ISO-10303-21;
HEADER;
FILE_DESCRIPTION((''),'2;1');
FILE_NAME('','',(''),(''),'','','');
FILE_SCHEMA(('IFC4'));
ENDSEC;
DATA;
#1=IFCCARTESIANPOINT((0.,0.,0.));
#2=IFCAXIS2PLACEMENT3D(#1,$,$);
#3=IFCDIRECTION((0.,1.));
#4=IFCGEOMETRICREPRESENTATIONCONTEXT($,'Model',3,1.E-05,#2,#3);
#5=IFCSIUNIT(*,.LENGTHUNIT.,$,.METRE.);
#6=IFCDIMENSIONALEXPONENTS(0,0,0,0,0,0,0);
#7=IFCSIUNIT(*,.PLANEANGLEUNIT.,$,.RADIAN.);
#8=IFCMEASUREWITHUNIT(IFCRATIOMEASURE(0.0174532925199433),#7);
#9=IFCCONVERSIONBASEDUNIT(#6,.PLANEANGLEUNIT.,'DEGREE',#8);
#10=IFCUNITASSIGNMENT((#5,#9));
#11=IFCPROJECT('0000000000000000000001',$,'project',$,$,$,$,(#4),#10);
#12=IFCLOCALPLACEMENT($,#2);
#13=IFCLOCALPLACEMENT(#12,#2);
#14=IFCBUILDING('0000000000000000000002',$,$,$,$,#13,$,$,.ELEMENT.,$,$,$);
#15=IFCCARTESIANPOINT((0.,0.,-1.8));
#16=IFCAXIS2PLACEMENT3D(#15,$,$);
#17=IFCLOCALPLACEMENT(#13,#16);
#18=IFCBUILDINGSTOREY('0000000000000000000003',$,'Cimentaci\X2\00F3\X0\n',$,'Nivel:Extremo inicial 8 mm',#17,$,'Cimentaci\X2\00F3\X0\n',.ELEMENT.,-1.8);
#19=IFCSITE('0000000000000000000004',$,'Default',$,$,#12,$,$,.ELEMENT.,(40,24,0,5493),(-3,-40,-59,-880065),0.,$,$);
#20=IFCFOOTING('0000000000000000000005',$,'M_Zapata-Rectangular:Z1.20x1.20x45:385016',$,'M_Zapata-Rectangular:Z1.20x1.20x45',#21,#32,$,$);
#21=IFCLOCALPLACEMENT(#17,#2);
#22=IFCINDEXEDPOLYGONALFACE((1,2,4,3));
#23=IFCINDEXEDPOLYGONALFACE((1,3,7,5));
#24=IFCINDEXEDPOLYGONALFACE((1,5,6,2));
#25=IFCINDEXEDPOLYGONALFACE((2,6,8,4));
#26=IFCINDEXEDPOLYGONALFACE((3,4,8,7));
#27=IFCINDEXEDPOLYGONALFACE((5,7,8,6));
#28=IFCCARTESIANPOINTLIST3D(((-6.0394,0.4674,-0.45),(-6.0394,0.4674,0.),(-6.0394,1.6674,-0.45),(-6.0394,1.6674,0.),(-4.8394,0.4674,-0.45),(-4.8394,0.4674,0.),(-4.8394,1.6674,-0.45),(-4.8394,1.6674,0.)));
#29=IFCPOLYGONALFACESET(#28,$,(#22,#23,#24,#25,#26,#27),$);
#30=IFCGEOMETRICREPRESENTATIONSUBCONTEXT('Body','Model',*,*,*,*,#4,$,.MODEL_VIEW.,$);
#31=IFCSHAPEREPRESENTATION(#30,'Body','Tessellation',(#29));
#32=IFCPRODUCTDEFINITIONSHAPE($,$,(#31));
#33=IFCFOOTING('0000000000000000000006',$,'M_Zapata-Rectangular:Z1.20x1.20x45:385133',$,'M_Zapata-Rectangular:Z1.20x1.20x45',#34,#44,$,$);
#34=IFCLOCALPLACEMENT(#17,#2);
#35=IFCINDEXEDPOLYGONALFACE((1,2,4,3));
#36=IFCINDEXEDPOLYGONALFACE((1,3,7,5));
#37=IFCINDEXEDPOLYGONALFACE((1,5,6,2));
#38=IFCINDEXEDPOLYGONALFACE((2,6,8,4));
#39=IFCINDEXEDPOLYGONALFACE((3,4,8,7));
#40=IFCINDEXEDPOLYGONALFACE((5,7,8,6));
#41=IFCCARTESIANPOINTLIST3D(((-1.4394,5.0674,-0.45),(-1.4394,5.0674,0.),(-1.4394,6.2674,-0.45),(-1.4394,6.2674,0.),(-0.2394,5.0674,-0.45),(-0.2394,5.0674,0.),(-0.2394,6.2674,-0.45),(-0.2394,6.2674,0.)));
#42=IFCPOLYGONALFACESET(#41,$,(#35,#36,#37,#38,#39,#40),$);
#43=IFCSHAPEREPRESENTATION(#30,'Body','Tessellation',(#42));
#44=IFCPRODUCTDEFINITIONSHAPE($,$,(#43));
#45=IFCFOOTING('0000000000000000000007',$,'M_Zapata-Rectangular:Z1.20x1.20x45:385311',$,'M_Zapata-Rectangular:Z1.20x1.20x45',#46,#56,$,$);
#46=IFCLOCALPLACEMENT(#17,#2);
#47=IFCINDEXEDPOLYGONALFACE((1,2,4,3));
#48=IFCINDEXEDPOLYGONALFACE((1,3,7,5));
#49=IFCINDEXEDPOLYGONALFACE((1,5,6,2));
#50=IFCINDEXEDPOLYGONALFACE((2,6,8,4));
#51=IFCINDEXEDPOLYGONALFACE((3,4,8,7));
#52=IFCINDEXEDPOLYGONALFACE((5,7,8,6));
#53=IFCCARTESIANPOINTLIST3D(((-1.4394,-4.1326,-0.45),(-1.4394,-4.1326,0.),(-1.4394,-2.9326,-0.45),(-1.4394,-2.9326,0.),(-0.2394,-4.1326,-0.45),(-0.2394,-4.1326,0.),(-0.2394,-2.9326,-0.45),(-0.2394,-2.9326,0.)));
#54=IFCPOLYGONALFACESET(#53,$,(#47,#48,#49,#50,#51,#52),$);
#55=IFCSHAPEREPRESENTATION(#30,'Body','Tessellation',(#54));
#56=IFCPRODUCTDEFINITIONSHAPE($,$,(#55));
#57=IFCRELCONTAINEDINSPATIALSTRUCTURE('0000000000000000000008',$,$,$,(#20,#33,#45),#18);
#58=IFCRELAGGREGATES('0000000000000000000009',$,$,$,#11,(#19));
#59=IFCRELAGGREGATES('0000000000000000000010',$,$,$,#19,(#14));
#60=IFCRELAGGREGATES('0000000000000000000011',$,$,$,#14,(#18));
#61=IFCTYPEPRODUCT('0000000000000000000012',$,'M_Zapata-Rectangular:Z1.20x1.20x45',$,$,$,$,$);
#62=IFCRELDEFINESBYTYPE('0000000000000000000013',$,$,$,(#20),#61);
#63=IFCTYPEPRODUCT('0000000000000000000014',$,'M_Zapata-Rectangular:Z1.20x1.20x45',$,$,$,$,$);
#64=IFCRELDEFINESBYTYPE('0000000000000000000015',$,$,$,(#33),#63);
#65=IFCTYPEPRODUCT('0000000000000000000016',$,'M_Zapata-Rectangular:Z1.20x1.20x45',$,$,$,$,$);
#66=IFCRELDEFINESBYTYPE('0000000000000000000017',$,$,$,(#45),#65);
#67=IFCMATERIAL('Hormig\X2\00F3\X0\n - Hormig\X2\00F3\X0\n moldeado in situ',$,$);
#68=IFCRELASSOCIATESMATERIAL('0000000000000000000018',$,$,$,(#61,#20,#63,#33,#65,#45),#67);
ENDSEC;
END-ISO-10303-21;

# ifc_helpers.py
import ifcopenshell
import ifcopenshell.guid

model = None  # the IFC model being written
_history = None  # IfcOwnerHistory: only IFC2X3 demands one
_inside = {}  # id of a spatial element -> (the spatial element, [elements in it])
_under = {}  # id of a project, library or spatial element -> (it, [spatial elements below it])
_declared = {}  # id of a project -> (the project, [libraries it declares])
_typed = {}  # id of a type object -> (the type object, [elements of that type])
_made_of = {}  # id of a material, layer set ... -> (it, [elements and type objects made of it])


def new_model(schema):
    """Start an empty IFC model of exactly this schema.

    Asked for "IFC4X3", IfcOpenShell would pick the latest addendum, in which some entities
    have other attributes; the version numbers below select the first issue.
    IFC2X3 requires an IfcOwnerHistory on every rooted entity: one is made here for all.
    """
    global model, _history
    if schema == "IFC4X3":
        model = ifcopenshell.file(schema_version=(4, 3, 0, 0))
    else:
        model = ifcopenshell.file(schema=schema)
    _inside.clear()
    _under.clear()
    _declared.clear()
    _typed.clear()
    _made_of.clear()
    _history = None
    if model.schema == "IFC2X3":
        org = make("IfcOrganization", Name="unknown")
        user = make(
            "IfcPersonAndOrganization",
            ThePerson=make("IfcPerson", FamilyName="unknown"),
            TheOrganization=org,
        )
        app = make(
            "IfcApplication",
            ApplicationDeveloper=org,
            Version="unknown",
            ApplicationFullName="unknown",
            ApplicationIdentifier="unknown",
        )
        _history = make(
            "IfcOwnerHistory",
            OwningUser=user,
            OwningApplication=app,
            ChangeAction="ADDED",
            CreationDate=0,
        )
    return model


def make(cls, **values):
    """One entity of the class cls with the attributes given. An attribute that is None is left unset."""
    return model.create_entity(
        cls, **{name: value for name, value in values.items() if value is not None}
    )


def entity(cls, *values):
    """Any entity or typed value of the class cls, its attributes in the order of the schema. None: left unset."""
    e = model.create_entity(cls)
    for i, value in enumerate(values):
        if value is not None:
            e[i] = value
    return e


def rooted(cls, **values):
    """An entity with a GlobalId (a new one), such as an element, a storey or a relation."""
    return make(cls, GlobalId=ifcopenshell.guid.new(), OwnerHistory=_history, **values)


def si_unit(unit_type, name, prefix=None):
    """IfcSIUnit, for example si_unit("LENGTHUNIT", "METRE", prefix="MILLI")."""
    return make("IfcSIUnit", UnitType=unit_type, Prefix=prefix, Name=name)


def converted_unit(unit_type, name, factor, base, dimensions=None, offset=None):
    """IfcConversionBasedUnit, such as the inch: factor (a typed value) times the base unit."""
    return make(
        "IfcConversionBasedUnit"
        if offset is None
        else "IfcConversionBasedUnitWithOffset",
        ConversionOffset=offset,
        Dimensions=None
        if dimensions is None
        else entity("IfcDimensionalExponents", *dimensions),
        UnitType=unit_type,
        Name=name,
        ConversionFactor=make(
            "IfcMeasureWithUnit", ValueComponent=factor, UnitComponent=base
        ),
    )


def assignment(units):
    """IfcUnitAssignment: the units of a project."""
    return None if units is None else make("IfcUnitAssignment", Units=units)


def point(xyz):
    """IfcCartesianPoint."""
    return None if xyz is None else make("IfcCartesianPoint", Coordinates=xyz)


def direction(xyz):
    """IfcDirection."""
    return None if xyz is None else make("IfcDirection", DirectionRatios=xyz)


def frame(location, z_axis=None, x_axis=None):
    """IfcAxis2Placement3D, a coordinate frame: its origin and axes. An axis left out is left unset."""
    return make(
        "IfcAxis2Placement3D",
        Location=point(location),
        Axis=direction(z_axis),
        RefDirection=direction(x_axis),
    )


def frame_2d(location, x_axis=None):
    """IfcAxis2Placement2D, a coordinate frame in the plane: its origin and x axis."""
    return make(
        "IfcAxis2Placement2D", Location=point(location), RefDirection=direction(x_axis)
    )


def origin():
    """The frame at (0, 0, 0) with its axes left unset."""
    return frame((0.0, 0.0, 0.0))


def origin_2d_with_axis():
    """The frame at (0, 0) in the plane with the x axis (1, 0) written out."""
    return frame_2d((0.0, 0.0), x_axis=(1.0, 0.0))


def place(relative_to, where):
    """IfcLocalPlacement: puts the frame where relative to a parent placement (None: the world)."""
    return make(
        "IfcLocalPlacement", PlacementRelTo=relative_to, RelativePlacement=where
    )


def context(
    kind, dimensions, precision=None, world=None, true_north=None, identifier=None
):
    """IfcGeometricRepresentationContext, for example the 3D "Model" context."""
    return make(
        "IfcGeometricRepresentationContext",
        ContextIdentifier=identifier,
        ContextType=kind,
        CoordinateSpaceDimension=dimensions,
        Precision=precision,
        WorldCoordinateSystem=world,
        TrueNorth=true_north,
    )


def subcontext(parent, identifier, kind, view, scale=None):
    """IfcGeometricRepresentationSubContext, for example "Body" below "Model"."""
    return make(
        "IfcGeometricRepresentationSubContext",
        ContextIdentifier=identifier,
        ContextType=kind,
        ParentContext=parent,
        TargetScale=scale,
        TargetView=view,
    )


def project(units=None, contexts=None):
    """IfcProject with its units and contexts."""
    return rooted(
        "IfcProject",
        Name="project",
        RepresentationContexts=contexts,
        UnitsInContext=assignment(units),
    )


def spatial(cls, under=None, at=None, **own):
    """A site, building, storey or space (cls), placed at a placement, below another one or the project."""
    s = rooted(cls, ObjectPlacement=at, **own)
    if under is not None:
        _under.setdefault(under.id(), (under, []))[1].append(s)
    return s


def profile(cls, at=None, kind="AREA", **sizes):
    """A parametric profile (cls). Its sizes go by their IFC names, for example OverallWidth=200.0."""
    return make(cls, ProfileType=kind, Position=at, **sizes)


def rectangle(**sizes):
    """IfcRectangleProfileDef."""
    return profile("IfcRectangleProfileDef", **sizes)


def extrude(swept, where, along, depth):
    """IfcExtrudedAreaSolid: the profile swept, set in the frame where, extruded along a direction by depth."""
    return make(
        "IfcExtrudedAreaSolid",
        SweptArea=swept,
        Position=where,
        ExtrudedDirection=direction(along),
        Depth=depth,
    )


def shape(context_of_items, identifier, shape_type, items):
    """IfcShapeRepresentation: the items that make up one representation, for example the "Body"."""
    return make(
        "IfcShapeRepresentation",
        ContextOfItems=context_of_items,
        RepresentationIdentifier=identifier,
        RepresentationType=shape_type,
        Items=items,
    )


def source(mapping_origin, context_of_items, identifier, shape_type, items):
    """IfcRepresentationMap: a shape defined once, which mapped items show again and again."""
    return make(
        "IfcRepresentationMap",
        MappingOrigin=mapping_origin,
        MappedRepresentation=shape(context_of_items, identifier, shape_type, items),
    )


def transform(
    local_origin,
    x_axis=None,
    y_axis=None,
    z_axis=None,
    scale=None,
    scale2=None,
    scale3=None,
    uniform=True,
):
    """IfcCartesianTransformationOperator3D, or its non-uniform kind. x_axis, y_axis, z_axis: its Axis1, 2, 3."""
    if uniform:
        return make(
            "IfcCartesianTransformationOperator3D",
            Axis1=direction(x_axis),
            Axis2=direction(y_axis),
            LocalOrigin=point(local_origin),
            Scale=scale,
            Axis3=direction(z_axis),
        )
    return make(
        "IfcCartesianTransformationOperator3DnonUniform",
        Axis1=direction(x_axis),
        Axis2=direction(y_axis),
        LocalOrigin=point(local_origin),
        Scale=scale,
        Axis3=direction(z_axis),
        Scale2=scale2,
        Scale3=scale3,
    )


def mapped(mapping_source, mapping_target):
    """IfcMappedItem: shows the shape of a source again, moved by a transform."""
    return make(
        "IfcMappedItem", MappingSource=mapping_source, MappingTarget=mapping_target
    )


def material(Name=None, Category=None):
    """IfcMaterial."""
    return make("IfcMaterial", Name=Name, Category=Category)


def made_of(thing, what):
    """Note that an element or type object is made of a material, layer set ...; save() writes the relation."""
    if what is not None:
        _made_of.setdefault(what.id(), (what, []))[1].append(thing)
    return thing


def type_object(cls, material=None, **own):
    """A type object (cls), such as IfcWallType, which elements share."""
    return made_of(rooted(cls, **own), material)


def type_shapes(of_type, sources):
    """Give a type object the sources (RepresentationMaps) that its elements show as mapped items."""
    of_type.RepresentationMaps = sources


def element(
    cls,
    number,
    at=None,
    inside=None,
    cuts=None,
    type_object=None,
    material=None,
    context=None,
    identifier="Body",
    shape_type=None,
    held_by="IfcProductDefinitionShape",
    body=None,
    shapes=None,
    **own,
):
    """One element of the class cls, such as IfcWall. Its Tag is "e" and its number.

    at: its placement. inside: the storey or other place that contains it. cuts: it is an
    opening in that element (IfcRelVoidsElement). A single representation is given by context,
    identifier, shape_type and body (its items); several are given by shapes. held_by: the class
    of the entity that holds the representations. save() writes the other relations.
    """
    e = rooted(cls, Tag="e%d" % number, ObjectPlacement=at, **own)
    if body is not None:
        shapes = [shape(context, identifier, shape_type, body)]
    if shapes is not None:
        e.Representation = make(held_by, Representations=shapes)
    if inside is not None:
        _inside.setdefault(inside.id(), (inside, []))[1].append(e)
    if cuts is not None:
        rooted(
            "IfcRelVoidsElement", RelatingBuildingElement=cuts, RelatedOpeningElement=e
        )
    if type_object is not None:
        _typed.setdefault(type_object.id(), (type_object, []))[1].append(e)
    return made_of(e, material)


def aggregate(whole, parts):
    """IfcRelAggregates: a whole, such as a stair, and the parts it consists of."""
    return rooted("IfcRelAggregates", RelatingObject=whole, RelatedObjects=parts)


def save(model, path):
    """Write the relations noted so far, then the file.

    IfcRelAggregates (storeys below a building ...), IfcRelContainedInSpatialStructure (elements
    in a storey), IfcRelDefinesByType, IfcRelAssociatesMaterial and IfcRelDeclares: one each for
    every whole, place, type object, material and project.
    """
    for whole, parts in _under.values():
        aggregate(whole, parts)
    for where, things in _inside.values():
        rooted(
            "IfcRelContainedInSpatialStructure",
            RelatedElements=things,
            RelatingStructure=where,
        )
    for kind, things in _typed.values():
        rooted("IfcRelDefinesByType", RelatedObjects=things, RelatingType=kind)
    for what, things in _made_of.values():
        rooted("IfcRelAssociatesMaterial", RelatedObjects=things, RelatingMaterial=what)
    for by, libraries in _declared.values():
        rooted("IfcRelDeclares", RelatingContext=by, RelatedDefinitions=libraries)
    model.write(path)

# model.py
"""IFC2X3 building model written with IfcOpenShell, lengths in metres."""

from ifc_helpers import new_model, entity, si_unit, converted_unit, direction, frame, origin, origin_2d_with_axis, place, context, subcontext, project, spatial, rectangle, extrude, source, transform, mapped, material, type_object, type_shapes, element, save


model = new_model("IFC2X3")

# Units and contexts
model_context = context("Model", 3, precision=1e-05, world=origin(), true_north=direction((0.0, 1.0)))
body_context = subcontext(model_context, "Body", "Model", "MODEL_VIEW")
ifc_project = project(units=[si_unit("LENGTHUNIT", "METRE"), converted_unit("PLANEANGLEUNIT", "DEGREE", entity("IfcRatioMeasure", 0.0174532925199433), si_unit("PLANEANGLEUNIT", "RADIAN"), dimensions=[0, 0, 0, 0, 0, 0, 0])], contexts=[model_context])

# Site, building, storey
site_placement = place(None, origin())
site = spatial("IfcSite", under=ifc_project, at=site_placement, Name="Default", CompositionType="ELEMENT", RefLatitude=(40, 24, 0, 5493), RefLongitude=(-3, -40, -59, -880065), RefElevation=0.0)
building_placement = place(site_placement, origin())
building = spatial("IfcBuilding", under=site, at=building_placement, CompositionType="ELEMENT")
storey_placement = place(building_placement, frame((0.0, 0.0, -1.8)))
storey = spatial("IfcBuildingStorey", under=building, at=storey_placement, Name="Cimentación", ObjectType="Nivel:Extremo inicial 8 mm", LongName="Cimentación", CompositionType="ELEMENT", Elevation=-1.8)

# Footings
ifc_material_1 = material(Name="Hormigón - Hormigón moldeado in situ")
type_product_1 = type_object("IfcTypeProduct", Name="M_Zapata-Rectangular:Z1.20x1.20x45", material=ifc_material_1)
shared_shape_1 = source(origin(), body_context, "Body", "SweptSolid", [
    extrude(rectangle(XDim=1.2, YDim=1.2, at=origin_2d_with_axis()), frame((0.0, 0.0, -0.45), z_axis=(0.0, 0.0, 1.0), x_axis=(-1.0, 0.0, 0.0)), (0.0, 0.0, 1.0), 0.45),
])
type_shapes(type_product_1, [shared_shape_1])
footing_1_placement = place(storey_placement, frame((-5.4394, 1.0674, 0.0)))
element("IfcFooting", 1, at=footing_1_placement, inside=storey, type_object=type_product_1, material=ifc_material_1, Name="M_Zapata-Rectangular:Z1.20x1.20x45:385016", ObjectType="M_Zapata-Rectangular:Z1.20x1.20x45", context=body_context, shape_type="MappedRepresentation", body=[
    mapped(shared_shape_1, transform((0.0, 0.0, 0.0), scale=1.0)),
])
type_product_2 = type_object("IfcTypeProduct", Name="M_Zapata-Rectangular:Z1.20x1.20x45", material=ifc_material_1)
shared_shape_2 = source(origin(), body_context, "Body", "SweptSolid", [
    extrude(rectangle(XDim=1.2, YDim=1.2, at=origin_2d_with_axis()), frame((0.0, 0.0, -0.45), z_axis=(0.0, 0.0, 1.0), x_axis=(-1.0, 0.0, 0.0)), (0.0, 0.0, 1.0), 0.45),
])
type_shapes(type_product_2, [shared_shape_2])
footing_2_placement = place(storey_placement, frame((-0.8394, 5.6674, 0.0)))
element("IfcFooting", 2, at=footing_2_placement, inside=storey, type_object=type_product_2, material=ifc_material_1, Name="M_Zapata-Rectangular:Z1.20x1.20x45:385133", ObjectType="M_Zapata-Rectangular:Z1.20x1.20x45", context=body_context, shape_type="MappedRepresentation", body=[
    mapped(shared_shape_2, transform((0.0, 0.0, 0.0), scale=1.0)),
])
type_product_3 = type_object("IfcTypeProduct", Name="M_Zapata-Rectangular:Z1.20x1.20x45", material=ifc_material_1)
shared_shape_3 = source(origin(), body_context, "Body", "SweptSolid", [
    extrude(rectangle(XDim=1.2, YDim=1.2, at=origin_2d_with_axis()), frame((0.0, 0.0, -0.45), z_axis=(0.0, 0.0, 1.0), x_axis=(-1.0, 0.0, 0.0)), (0.0, 0.0, 1.0), 0.45),
])
type_shapes(type_product_3, [shared_shape_3])
footing_3_placement = place(storey_placement, frame((-0.8394, -3.5326, 0.0)))
element("IfcFooting", 3, at=footing_3_placement, inside=storey, type_object=type_product_3, material=ifc_material_1, Name="M_Zapata-Rectangular:Z1.20x1.20x45:385311", ObjectType="M_Zapata-Rectangular:Z1.20x1.20x45", context=body_context, shape_type="MappedRepresentation", body=[
    mapped(shared_shape_3, transform((0.0, 0.0, 0.0), scale=1.0)),
])

save(model, "model.ifc")
